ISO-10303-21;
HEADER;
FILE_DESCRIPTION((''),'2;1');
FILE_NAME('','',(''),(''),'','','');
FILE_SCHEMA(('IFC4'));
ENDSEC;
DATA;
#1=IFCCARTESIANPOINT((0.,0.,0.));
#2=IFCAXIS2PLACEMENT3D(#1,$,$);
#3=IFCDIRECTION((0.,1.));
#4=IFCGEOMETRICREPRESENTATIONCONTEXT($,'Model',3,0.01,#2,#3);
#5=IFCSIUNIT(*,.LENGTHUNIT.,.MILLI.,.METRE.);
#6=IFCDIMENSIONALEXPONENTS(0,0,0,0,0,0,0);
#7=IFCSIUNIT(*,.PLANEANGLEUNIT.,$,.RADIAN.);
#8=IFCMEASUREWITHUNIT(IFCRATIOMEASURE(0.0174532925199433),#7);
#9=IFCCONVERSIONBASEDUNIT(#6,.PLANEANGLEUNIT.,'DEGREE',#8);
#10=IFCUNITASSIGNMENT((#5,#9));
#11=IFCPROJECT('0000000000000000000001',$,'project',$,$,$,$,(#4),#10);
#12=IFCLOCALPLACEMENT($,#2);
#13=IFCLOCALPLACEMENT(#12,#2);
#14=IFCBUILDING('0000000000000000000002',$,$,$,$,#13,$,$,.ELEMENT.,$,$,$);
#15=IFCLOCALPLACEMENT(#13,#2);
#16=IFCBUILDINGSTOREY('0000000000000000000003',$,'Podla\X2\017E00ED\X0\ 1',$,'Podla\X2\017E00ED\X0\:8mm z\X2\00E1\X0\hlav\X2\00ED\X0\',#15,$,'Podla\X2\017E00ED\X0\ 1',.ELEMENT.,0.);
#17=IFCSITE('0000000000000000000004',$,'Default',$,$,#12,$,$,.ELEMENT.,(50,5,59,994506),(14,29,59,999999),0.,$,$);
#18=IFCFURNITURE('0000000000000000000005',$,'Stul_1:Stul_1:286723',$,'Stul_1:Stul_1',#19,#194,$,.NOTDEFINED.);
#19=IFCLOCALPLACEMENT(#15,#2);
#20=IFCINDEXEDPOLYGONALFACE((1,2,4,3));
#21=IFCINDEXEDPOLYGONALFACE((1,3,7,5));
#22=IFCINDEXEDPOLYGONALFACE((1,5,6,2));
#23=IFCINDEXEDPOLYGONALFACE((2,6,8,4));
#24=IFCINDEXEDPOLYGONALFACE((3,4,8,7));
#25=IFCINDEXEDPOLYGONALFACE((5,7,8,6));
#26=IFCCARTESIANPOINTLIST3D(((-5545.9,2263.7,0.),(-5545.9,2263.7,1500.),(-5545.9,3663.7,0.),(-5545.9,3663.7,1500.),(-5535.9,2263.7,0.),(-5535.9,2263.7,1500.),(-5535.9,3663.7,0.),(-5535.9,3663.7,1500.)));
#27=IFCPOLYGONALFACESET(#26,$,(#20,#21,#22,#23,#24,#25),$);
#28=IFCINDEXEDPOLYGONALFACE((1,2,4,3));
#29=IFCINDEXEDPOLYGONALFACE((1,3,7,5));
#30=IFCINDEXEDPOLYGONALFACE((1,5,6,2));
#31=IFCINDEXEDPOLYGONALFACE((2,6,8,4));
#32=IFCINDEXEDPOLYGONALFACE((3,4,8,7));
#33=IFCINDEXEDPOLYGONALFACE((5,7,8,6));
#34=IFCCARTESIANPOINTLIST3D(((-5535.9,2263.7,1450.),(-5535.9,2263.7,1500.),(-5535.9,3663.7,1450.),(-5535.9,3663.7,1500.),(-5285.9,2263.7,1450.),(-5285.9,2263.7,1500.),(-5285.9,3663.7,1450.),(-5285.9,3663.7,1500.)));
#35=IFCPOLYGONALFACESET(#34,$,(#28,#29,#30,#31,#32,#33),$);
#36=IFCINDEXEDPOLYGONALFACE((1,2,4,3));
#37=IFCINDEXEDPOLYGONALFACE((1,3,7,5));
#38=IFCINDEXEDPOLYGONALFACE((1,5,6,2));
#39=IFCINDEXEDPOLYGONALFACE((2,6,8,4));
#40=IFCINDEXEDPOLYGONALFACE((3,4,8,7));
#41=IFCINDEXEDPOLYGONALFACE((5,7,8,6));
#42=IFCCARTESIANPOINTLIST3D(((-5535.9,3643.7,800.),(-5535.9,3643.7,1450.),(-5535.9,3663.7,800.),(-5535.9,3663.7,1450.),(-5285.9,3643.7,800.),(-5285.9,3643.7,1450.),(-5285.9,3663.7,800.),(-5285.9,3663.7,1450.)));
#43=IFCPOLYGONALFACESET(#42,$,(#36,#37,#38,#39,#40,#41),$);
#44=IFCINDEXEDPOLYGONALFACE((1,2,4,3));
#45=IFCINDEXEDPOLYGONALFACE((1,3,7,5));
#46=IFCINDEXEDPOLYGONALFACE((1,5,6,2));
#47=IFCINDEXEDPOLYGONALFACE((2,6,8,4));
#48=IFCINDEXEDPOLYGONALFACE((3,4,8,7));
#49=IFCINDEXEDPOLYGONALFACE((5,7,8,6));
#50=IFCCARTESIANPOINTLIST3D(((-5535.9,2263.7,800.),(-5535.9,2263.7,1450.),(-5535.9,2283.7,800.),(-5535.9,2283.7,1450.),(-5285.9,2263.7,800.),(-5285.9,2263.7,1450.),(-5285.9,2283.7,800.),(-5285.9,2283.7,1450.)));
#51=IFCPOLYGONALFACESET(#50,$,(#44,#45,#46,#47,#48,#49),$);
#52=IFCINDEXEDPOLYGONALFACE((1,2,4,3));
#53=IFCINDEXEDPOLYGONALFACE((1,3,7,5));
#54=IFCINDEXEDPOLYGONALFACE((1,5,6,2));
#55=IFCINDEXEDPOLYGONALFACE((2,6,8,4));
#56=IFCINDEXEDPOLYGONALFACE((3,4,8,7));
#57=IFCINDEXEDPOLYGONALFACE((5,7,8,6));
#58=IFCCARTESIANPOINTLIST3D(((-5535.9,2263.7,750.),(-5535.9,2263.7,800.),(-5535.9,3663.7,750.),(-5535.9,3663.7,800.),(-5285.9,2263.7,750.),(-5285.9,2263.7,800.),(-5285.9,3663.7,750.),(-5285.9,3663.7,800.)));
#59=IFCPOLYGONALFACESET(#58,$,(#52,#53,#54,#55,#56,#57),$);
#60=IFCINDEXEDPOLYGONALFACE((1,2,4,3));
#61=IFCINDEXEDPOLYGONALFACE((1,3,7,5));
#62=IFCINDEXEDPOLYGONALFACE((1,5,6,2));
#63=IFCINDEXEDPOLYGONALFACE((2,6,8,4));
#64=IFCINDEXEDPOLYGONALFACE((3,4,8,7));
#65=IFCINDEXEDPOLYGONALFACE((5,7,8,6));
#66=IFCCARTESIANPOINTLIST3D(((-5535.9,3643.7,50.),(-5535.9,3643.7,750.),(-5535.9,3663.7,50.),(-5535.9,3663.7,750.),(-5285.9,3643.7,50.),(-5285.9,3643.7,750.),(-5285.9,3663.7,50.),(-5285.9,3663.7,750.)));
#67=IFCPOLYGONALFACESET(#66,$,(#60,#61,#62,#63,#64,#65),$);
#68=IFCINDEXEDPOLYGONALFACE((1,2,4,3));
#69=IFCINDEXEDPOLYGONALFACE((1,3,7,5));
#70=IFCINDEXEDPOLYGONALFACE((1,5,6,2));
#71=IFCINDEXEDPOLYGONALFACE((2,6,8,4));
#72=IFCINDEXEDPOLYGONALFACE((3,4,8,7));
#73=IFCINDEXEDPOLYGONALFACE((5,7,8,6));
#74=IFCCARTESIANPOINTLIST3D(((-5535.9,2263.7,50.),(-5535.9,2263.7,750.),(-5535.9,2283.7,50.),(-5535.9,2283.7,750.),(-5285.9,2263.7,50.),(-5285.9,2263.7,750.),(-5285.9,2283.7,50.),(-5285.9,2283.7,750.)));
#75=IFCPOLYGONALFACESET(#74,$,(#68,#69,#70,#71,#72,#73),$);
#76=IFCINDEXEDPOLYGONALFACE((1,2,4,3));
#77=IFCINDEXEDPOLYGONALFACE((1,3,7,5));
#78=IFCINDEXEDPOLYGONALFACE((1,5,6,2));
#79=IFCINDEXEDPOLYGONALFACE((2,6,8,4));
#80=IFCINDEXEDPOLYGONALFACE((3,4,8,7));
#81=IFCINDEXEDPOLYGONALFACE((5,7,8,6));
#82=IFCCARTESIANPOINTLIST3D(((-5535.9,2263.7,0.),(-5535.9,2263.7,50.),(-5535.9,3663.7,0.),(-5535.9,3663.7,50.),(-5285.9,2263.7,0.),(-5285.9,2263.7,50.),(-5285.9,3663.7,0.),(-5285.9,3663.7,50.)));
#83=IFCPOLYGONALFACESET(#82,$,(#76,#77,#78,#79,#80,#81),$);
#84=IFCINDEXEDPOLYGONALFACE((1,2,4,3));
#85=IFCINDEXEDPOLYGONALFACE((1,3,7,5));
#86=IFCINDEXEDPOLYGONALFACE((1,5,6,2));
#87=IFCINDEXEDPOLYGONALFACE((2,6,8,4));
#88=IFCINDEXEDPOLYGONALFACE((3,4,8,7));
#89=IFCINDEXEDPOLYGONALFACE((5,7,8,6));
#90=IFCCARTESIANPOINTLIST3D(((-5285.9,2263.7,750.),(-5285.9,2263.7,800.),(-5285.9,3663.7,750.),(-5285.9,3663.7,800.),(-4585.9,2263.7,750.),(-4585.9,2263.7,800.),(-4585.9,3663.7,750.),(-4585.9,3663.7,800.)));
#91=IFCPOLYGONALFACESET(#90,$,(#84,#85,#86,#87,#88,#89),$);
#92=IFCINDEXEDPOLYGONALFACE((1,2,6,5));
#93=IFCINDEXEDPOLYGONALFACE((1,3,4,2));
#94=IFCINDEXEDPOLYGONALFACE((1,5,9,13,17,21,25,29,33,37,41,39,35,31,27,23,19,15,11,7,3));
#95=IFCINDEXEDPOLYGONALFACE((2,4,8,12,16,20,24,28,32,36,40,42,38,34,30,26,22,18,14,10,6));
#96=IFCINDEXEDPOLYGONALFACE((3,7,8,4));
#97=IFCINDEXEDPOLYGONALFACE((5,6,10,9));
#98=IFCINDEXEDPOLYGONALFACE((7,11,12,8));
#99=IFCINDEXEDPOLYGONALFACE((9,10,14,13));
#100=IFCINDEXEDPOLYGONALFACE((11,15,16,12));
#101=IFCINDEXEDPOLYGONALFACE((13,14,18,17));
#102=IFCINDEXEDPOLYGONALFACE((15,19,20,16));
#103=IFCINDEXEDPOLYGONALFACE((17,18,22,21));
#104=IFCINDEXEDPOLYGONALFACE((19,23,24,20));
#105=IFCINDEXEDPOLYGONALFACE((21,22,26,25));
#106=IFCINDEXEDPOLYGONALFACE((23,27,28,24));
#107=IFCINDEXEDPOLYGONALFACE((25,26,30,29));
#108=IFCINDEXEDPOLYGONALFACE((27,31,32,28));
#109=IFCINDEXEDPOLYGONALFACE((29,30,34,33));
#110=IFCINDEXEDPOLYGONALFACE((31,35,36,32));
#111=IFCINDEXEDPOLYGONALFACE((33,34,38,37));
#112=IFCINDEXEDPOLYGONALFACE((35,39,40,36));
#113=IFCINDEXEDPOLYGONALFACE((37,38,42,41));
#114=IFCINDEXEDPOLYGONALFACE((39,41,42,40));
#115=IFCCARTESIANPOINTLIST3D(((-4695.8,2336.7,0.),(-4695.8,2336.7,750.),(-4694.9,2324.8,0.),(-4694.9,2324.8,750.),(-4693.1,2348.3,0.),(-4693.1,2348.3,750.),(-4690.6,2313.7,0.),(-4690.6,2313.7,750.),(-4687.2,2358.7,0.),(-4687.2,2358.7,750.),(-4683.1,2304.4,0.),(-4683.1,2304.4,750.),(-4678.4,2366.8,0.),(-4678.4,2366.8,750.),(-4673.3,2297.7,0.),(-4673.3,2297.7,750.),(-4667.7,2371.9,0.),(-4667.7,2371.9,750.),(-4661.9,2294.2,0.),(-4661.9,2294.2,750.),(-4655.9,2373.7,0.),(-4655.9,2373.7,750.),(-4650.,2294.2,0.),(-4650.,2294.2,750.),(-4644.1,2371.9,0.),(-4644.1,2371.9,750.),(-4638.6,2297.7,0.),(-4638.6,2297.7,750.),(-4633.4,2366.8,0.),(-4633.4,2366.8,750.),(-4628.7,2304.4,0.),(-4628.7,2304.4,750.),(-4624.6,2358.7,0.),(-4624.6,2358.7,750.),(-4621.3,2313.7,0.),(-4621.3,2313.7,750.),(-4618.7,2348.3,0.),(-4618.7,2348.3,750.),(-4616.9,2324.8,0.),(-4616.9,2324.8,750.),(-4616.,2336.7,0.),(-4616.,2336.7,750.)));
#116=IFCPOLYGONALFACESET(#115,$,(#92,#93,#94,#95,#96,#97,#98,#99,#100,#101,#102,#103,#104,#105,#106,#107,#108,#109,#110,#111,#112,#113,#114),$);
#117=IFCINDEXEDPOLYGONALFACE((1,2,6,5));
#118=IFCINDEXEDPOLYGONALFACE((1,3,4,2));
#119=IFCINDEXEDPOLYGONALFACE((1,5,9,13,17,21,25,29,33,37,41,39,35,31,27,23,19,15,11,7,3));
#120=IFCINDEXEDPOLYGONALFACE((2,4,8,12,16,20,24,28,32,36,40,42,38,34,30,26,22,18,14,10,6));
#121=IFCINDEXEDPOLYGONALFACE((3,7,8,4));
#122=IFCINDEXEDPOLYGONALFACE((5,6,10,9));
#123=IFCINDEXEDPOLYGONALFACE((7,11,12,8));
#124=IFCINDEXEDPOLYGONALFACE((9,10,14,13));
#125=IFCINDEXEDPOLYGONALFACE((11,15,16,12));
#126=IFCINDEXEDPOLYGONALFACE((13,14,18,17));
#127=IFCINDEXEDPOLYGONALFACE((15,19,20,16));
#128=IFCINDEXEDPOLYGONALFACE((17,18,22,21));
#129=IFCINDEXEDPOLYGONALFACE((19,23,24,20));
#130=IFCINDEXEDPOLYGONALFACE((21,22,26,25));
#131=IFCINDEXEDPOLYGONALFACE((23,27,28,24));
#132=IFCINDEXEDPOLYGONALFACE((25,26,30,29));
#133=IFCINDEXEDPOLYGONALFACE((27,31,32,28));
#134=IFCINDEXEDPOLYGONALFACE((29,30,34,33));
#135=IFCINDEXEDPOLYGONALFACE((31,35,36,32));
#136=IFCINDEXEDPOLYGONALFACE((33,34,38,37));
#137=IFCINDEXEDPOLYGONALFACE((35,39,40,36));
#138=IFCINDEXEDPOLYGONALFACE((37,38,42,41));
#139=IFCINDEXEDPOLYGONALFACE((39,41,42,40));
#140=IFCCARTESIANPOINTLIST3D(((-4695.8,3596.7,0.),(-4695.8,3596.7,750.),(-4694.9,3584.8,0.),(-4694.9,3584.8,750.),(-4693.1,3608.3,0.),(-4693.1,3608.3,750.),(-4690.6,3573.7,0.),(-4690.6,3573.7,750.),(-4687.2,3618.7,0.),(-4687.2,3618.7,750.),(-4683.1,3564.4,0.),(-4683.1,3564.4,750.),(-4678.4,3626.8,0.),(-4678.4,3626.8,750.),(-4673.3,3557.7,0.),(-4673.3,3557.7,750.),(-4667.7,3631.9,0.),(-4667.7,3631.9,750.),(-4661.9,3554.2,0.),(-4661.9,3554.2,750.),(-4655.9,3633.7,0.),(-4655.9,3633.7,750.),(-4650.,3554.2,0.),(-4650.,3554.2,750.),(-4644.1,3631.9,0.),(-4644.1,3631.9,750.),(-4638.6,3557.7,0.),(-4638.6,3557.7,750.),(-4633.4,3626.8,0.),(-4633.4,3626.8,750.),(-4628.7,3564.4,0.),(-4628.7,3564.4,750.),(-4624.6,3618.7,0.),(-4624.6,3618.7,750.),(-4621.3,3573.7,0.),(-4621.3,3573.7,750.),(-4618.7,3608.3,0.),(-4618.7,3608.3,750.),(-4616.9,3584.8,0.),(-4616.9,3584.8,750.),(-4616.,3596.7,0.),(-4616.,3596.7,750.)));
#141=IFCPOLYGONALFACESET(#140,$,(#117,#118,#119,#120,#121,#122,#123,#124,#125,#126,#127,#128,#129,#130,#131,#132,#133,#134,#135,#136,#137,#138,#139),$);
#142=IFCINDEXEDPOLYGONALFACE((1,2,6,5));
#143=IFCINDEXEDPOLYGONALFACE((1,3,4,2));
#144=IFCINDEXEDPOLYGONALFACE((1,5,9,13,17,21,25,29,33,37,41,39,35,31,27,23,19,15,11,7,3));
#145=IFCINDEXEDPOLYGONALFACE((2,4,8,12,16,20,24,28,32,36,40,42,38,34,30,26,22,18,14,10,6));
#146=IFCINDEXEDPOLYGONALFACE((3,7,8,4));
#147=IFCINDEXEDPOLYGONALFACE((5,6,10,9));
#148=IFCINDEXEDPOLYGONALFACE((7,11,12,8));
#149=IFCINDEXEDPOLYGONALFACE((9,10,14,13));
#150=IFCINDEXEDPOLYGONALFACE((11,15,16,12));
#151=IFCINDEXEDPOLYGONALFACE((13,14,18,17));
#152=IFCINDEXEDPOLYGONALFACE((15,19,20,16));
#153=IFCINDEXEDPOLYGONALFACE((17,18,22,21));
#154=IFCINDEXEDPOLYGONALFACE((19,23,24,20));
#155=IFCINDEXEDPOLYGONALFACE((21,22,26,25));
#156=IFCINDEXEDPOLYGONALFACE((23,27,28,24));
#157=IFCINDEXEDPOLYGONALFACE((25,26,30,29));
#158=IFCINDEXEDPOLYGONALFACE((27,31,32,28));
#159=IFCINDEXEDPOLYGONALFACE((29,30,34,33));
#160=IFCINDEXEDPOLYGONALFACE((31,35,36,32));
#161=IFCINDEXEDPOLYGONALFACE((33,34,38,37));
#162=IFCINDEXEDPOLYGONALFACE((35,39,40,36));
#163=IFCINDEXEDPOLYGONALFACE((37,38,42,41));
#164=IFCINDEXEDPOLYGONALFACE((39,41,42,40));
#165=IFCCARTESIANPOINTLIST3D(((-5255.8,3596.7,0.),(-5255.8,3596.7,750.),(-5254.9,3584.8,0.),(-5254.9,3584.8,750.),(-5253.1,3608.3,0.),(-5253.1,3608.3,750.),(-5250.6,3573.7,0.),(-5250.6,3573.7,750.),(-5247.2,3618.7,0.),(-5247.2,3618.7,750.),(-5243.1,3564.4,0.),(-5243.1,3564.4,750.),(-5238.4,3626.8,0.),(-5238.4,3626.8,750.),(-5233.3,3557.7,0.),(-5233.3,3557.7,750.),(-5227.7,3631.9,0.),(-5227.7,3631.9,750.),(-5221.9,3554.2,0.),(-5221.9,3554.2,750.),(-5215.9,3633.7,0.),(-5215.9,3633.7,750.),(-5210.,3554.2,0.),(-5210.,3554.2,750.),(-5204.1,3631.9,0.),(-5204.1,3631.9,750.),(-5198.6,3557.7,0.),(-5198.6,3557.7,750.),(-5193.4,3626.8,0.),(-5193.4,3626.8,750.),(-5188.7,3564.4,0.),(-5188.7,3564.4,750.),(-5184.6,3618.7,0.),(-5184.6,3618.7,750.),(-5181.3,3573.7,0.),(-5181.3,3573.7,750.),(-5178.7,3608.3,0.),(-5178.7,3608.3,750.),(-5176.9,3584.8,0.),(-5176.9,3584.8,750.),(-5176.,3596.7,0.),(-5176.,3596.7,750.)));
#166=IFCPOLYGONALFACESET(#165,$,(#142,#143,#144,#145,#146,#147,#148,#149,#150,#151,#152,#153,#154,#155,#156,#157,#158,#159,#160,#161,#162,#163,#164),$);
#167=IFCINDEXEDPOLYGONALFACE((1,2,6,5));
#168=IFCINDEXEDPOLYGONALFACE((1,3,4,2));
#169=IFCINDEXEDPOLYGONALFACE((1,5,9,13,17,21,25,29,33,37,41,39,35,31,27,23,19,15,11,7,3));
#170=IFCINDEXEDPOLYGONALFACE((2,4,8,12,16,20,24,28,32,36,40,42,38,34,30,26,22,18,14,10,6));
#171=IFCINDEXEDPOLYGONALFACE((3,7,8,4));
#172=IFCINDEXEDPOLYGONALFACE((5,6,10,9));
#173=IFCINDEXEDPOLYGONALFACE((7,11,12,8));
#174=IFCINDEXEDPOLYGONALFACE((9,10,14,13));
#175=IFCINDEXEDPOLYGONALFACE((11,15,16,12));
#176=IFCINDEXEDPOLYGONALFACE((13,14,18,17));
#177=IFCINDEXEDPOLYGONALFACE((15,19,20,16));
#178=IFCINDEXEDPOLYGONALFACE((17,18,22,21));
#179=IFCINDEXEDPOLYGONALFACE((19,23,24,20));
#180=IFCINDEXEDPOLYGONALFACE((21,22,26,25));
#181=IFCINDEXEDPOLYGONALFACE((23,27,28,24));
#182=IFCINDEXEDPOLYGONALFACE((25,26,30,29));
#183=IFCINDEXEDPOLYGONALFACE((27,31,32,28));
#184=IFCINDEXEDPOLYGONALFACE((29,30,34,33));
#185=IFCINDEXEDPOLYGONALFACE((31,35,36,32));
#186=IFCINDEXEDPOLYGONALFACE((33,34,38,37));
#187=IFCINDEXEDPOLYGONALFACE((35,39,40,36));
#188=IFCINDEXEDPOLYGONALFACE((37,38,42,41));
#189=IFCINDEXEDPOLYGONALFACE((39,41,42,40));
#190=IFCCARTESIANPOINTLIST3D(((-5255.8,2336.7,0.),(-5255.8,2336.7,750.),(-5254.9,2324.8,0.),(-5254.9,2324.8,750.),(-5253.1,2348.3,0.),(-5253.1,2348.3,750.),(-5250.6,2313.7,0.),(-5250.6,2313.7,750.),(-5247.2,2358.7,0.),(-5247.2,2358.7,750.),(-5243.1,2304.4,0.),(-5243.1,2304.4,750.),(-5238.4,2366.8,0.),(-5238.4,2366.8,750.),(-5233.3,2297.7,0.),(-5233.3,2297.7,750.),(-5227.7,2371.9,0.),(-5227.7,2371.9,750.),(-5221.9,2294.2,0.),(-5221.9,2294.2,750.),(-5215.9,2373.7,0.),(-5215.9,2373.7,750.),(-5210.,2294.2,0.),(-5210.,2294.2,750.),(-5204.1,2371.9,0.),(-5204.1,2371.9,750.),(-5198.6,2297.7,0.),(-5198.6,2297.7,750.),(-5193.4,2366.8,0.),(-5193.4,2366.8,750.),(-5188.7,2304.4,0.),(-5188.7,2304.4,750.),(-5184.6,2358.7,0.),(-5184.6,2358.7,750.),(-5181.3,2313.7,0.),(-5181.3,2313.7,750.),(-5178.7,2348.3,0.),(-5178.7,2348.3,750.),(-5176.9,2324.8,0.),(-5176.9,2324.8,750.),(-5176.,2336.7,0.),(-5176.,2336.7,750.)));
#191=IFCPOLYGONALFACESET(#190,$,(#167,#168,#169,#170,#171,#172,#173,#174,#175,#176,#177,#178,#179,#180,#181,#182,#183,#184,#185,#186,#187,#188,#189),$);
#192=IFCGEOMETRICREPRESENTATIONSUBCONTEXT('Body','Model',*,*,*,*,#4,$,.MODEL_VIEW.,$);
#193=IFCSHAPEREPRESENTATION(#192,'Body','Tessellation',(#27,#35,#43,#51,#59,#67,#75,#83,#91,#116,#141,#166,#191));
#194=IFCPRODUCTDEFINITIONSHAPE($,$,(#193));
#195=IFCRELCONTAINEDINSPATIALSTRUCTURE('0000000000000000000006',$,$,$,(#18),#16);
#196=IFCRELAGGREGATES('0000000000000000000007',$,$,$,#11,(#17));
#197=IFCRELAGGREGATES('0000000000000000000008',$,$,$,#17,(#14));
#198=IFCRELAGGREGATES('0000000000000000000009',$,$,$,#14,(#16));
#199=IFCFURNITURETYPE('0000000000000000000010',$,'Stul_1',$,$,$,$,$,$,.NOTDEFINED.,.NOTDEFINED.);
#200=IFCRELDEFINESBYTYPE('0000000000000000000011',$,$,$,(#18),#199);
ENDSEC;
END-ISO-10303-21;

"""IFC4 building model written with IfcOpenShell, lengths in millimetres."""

from ifc_helpers import new_model, entity, si_unit, converted_unit, direction, frame, frame_2d, origin, origin_2d_with_axis, place, context, subcontext, project, spatial, rectangle, circle, extrude, source, transform, mapped, type_object, type_shapes, element, save


model = new_model("IFC4")

# Units and contexts
model_context = context("Model", 3, precision=0.01, world=origin(), true_north=direction((0.0, 1.0)))
body_context = subcontext(model_context, "Body", "Model", "MODEL_VIEW")
ifc_project = project(units=[si_unit("LENGTHUNIT", "METRE", prefix="MILLI"), converted_unit("PLANEANGLEUNIT", "DEGREE", entity("IfcRatioMeasure", 0.0174532925199433), si_unit("PLANEANGLEUNIT", "RADIAN"), dimensions=[0, 0, 0, 0, 0, 0, 0])], contexts=[model_context])

# Site, building, storey
site_placement = place(None, origin())
site = spatial("IfcSite", under=ifc_project, at=site_placement, Name="Default", CompositionType="ELEMENT", RefLatitude=(50, 5, 59, 994506), RefLongitude=(14, 29, 59, 999999), RefElevation=0.0)
building_placement = place(site_placement, origin())
building = spatial("IfcBuilding", under=site, at=building_placement, CompositionType="ELEMENT")
storey_placement = place(building_placement, origin())
storey = spatial("IfcBuildingStorey", under=building, at=storey_placement, Name="Podlaží 1", ObjectType="Podlaží:8mm záhlaví", LongName="Podlaží 1", CompositionType="ELEMENT", Elevation=0.0)

# Furniture
furniture_type = type_object("IfcFurnitureType", Name="Stul_1", AssemblyPlace="NOTDEFINED", PredefinedType="NOTDEFINED")
shared_shape_1 = source(origin(), body_context, "Body", "SweptSolid", [
    extrude(rectangle(XDim=1400.0, YDim=10.0, at=origin_2d_with_axis()), frame((0.0, 605.0, 0.0), z_axis=(0.0, 0.0, 1.0), x_axis=(-1.0, 0.0, 0.0)), (0.0, 0.0, 1.0), 1500.0),
    extrude(rectangle(XDim=1400.0, YDim=250.0, at=frame_2d((0.0, 0.0), x_axis=(1.0, 0.0))), frame((0.0, 475.0, 1450.0), z_axis=(0.0, 0.0, 1.0), x_axis=(-1.0, 0.0, 0.0)), (0.0, 0.0, 1.0), 50.0),
    extrude(rectangle(XDim=20.0, YDim=250.0, at=origin_2d_with_axis()), frame((690.0, 475.0, 800.0), z_axis=(0.0, 0.0, 1.0), x_axis=(-1.0, 0.0, 0.0)), (0.0, 0.0, 1.0), 650.0),
    extrude(rectangle(XDim=20.0, YDim=250.0, at=frame_2d((0.0, 0.0), x_axis=(1.0, 0.0))), frame((-690.0, 475.0, 800.0), z_axis=(0.0, 0.0, 1.0), x_axis=(-1.0, 0.0, 0.0)), (0.0, 0.0, 1.0), 650.0),
    extrude(rectangle(XDim=1400.0, YDim=250.0, at=origin_2d_with_axis()), frame((0.0, 475.0, 750.0), z_axis=(0.0, 0.0, 1.0), x_axis=(-1.0, 0.0, 0.0)), (0.0, 0.0, 1.0), 50.0),
    extrude(rectangle(XDim=20.0, YDim=250.0, at=origin_2d_with_axis()), frame((690.0, 475.0, 50.0), z_axis=(0.0, 0.0, 1.0), x_axis=(-1.0, 0.0, 0.0)), (0.0, 0.0, 1.0), 700.0),
    extrude(rectangle(XDim=20.0, YDim=250.0, at=frame_2d((0.0, 0.0), x_axis=(1.0, 0.0))), frame((-690.0, 475.0, 50.0), z_axis=(0.0, 0.0, 1.0), x_axis=(-1.0, 0.0, 0.0)), (0.0, 0.0, 1.0), 700.0),
    extrude(rectangle(XDim=1400.0, YDim=250.0, at=origin_2d_with_axis()), frame((0.0, 475.0, 0.0), z_axis=(0.0, 0.0, 1.0), x_axis=(-1.0, 0.0, 0.0)), (0.0, 0.0, 1.0), 50.0),
    extrude(rectangle(XDim=1400.0, YDim=700.0, at=origin_2d_with_axis()), frame((0.0, 0.0, 750.0), z_axis=(0.0, 0.0, 1.0), x_axis=(-1.0, 0.0, 0.0)), (0.0, 0.0, 1.0), 50.0),
    extrude(circle(Radius=40.0, at=frame_2d((0.0, 0.0), x_axis=(1.0, 0.0))), frame((-630.0, -280.0, 0.0)), (0.0, 0.0, 1.0), 750.0),
    extrude(circle(Radius=40.0, at=frame_2d((0.0, 0.0), x_axis=(1.0, 0.0))), frame((630.0, -280.0, 0.0)), (0.0, 0.0, 1.0), 750.0),
    extrude(circle(Radius=40.0, at=frame_2d((0.0, 0.0), x_axis=(1.0, 0.0))), frame((630.0, 280.0, 0.0)), (0.0, 0.0, 1.0), 750.0),
    extrude(circle(Radius=40.0, at=frame_2d((0.0, 0.0), x_axis=(1.0, 0.0))), frame((-630.0, 280.0, 0.0)), (0.0, 0.0, 1.0), 750.0),
])
type_shapes(furniture_type, [shared_shape_1])
for number, where, z_axis, x_axis, name in (
    (1, (-4935.9, 2963.7, 0.0), (0.0, 0.0, 1.0), (0.0, 1.0, 0.0), "Stul_1:Stul_1:286723"),
):
    element("IfcFurniture", number, at=place(storey_placement, frame(where, z_axis=z_axis, x_axis=x_axis)), inside=storey, type_object=furniture_type, Name=name, ObjectType="Stul_1:Stul_1", PredefinedType="NOTDEFINED", context=body_context, shape_type="MappedRepresentation", body=[
        mapped(shared_shape_1, transform((0.0, 0.0, 0.0), scale=1.0)),
    ])

save(model, "model.ifc")
